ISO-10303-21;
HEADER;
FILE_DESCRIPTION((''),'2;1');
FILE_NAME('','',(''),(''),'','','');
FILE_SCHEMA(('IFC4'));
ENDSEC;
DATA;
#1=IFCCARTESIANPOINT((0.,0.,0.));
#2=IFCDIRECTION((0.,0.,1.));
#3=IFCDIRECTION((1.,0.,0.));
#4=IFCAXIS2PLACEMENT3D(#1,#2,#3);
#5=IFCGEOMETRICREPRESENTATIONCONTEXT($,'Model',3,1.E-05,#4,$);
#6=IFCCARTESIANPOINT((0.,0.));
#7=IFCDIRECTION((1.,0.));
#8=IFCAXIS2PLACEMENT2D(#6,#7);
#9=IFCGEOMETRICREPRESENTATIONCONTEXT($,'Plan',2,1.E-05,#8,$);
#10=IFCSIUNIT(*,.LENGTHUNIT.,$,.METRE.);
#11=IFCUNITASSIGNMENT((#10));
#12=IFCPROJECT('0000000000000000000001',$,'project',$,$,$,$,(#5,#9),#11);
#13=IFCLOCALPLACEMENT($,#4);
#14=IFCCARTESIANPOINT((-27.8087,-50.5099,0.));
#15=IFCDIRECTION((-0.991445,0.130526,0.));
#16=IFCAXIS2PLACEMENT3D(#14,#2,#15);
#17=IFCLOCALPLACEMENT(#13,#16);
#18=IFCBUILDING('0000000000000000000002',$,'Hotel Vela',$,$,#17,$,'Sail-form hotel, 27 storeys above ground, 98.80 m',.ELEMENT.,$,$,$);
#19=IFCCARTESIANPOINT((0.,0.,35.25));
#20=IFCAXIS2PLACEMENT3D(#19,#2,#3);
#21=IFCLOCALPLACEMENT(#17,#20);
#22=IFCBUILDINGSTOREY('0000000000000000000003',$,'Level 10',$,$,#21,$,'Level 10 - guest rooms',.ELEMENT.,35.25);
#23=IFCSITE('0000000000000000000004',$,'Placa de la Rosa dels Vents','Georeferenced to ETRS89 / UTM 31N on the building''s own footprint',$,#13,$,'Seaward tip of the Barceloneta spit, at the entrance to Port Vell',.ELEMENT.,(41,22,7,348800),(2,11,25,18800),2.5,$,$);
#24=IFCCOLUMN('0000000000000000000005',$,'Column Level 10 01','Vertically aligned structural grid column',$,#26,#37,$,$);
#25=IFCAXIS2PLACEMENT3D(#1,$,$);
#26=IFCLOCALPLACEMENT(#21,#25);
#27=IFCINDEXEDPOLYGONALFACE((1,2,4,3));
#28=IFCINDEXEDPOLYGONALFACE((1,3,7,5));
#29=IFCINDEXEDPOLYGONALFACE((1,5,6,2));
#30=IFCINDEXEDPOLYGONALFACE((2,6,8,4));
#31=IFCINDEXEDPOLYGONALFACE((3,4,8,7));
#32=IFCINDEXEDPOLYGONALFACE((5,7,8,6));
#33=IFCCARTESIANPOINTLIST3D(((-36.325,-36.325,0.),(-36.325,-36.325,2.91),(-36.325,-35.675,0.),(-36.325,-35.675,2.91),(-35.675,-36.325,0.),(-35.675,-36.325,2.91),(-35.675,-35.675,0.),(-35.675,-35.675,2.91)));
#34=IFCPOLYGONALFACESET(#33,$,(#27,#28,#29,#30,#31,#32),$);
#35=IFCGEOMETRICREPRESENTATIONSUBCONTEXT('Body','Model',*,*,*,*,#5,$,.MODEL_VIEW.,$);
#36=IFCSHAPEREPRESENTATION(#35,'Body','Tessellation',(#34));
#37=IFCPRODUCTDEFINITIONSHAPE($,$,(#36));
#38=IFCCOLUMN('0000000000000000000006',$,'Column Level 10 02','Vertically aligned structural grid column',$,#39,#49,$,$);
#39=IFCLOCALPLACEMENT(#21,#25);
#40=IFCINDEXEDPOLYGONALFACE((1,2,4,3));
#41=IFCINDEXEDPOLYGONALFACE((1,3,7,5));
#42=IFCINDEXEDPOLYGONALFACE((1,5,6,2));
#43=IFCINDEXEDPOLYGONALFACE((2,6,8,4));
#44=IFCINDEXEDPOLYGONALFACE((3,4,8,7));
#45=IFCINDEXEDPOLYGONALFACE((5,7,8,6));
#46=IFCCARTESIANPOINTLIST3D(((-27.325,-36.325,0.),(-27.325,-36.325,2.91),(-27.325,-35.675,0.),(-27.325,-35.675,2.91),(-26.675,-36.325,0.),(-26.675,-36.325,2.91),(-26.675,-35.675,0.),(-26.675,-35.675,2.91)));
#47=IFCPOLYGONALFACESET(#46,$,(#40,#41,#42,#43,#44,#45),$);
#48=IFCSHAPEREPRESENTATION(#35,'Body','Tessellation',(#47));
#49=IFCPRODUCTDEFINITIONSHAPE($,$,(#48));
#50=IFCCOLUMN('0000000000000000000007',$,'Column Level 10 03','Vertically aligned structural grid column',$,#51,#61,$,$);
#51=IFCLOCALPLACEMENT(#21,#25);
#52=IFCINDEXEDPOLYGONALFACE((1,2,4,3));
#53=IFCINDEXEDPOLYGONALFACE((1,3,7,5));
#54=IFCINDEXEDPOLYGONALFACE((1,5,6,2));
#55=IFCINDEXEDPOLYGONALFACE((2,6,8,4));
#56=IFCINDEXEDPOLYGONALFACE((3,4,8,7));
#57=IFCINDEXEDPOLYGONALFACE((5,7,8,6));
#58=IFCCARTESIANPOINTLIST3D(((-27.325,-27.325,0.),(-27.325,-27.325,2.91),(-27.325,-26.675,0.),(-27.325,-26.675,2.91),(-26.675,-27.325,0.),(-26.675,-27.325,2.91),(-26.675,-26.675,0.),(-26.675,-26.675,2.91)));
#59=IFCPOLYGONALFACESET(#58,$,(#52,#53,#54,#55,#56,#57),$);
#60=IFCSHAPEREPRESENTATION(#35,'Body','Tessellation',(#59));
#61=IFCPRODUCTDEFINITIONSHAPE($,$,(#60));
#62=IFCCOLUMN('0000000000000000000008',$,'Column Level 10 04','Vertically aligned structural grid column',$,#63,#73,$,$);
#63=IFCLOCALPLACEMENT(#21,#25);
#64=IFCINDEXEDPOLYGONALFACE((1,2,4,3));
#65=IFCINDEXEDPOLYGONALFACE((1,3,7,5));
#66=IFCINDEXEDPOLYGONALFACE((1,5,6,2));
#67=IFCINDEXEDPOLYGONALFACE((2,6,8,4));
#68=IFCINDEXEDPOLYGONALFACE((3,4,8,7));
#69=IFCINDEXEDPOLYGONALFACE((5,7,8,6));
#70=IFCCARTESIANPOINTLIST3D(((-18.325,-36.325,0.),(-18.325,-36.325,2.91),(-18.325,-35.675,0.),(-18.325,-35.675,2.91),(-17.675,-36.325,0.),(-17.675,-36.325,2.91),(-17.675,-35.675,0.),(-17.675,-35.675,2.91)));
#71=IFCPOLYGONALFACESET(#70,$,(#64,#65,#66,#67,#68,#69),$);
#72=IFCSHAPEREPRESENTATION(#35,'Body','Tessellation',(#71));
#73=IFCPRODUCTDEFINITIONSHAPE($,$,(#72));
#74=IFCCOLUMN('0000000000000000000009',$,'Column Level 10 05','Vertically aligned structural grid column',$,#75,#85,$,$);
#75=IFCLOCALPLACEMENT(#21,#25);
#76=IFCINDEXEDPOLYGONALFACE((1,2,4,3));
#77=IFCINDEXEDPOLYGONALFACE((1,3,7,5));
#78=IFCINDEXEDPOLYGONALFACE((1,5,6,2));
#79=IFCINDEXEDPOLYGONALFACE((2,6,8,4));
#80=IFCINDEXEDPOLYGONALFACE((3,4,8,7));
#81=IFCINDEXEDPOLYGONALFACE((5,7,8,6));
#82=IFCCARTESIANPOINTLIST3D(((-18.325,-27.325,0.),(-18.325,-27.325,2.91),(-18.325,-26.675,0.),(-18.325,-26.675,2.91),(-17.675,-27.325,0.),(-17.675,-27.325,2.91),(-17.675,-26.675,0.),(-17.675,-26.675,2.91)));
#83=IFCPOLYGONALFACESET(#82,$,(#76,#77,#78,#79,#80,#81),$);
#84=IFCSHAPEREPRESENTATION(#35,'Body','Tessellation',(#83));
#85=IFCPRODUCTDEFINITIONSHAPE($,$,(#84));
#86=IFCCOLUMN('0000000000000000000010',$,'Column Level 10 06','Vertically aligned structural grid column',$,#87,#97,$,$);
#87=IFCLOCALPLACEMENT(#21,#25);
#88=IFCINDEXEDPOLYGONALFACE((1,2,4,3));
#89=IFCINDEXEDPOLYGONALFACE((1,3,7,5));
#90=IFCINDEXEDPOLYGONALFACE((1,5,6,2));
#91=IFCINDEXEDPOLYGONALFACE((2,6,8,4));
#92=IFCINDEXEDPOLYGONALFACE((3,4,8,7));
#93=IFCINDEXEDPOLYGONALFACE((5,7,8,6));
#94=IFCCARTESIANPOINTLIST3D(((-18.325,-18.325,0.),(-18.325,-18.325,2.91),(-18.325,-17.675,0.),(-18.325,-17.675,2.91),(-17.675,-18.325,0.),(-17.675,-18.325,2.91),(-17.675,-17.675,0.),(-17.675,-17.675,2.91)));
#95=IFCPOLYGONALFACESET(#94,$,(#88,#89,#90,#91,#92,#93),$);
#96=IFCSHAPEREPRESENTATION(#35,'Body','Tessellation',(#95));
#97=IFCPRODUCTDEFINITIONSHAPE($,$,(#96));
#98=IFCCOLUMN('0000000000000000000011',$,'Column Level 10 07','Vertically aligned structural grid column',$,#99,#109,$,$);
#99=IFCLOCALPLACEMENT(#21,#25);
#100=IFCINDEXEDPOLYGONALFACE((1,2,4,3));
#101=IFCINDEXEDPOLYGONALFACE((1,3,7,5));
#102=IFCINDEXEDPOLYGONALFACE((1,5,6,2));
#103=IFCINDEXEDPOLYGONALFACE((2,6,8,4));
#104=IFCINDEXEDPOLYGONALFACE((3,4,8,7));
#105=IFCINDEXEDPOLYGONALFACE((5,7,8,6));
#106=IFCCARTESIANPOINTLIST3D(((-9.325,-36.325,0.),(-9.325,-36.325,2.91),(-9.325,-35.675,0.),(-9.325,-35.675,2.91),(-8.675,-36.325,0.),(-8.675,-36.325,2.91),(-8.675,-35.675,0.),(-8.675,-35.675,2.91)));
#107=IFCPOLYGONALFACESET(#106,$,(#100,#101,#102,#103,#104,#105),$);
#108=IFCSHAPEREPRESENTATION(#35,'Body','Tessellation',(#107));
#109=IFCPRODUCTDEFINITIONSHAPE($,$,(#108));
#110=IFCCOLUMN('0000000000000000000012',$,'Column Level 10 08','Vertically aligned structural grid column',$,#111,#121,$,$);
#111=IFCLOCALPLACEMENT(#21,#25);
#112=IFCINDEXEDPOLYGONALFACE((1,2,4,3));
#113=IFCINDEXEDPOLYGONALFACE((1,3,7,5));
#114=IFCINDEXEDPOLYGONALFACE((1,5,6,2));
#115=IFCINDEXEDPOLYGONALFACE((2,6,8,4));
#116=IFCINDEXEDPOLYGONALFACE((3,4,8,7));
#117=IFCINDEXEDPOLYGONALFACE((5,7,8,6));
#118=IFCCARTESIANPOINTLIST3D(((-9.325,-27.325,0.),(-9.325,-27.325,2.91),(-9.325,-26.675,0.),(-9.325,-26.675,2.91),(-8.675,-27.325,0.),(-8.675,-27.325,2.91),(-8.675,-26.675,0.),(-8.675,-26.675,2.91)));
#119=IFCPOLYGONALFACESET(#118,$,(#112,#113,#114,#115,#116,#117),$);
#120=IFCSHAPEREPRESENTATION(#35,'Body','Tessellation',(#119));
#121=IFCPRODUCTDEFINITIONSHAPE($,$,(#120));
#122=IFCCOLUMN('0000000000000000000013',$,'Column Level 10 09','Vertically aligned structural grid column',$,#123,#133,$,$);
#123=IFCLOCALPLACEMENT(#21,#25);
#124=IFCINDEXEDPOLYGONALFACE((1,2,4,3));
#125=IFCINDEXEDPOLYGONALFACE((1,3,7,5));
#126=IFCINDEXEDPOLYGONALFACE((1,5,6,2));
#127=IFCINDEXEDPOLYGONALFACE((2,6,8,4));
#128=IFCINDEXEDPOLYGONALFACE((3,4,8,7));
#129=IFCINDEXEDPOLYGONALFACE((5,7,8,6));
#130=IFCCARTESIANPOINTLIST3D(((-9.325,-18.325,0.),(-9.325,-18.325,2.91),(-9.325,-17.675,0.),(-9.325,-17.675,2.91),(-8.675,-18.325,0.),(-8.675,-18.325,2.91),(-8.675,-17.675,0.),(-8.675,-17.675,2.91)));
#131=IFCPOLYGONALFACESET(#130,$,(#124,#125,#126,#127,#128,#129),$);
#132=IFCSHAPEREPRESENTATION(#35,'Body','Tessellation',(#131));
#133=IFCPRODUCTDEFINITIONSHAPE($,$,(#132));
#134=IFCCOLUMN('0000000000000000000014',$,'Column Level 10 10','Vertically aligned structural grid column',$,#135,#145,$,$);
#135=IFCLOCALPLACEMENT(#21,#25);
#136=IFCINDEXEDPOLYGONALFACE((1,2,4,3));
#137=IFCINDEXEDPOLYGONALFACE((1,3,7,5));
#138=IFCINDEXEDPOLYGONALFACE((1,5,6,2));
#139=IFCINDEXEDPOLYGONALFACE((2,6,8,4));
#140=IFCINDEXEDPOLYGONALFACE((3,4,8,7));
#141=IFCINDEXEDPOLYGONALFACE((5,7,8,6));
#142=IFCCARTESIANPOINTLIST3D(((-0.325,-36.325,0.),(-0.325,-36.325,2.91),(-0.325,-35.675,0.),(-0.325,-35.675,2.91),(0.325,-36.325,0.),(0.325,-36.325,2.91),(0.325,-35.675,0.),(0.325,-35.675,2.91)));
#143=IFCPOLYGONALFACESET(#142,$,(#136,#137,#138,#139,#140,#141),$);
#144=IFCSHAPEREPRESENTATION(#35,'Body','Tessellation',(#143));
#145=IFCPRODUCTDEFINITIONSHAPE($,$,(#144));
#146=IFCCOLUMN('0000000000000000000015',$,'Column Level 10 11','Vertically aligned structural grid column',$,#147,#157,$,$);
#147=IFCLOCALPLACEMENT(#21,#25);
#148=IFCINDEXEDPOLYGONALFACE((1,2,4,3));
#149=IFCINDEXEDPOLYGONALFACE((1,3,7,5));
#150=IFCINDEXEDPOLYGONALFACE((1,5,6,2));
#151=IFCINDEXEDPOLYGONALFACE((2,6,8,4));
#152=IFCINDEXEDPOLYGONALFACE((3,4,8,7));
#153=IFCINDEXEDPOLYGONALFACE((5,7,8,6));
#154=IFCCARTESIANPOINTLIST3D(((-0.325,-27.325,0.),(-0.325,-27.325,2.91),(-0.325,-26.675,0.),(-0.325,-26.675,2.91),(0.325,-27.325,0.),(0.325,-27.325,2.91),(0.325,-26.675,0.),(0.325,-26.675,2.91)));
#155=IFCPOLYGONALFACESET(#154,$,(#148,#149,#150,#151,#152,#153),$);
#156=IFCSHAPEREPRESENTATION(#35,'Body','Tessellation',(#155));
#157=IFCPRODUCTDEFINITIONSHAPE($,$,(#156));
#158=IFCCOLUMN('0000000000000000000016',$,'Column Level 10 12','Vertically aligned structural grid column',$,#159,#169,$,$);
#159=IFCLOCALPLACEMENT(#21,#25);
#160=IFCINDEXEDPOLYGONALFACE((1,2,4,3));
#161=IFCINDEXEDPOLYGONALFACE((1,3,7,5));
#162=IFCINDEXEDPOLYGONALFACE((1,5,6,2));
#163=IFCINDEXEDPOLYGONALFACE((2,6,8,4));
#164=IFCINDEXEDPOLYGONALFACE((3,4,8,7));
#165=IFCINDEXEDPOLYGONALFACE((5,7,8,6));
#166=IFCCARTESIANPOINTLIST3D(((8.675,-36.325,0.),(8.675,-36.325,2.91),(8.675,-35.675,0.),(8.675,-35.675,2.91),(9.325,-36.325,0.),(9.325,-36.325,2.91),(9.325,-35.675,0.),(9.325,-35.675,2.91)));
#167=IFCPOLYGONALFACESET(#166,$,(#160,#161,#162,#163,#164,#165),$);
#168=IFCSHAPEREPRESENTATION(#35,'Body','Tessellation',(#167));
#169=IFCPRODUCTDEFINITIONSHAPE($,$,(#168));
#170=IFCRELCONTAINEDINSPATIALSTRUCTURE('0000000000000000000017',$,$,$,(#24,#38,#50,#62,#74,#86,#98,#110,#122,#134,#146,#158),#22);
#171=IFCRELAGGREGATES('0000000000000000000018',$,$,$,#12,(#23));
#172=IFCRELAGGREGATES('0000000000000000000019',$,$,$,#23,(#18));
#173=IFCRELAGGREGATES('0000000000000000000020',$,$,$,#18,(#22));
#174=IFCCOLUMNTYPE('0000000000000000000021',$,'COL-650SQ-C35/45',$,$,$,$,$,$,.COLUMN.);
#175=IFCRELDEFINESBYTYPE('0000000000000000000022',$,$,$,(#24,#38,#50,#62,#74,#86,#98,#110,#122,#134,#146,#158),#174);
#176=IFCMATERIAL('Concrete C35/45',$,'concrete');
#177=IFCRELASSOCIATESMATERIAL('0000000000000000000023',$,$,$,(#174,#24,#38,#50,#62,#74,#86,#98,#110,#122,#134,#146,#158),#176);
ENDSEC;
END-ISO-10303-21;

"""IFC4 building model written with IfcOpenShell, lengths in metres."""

from ifc_helpers import new_model, si_unit, frame, origin_with_axes, origin_2d_with_axis, place, context, subcontext, project, spatial, line, indexed_curve, rectangle, outline, extrude, material, material_profile, profile_set, profile_usage, type_object, element, save


model = new_model("IFC4")

# Units and contexts
model_context = context("Model", 3, precision=1e-05, world=origin_with_axes())
plan_context = context("Plan", 2, precision=1e-05, world=origin_2d_with_axis())
body_context = subcontext(model_context, "Body", "Model", "MODEL_VIEW")
ifc_project = project(units=[si_unit("LENGTHUNIT", "METRE")], contexts=[model_context, plan_context])

# Site, building, storey
site_placement = place(None, origin_with_axes())
site = spatial("IfcSite", under=ifc_project, at=site_placement, Name="Placa de la Rosa dels Vents", Description="Georeferenced to ETRS89 / UTM 31N on the building's own footprint", LongName="Seaward tip of the Barceloneta spit, at the entrance to Port Vell", CompositionType="ELEMENT", RefLatitude=(41, 22, 7, 348800), RefLongitude=(2, 11, 25, 18800), RefElevation=2.5)
building_placement = place(site_placement, frame((-27.8087, -50.5099, 0.0), z_axis=(0.0, 0.0, 1.0), x_axis=(-0.991445, 0.130526, 0.0)))
building = spatial("IfcBuilding", under=site, at=building_placement, Name="Hotel Vela", LongName="Sail-form hotel, 27 storeys above ground, 98.80 m", CompositionType="ELEMENT")
storey_placement = place(building_placement, frame((0.0, 0.0, 35.25), z_axis=(0.0, 0.0, 1.0), x_axis=(1.0, 0.0, 0.0)))
storey = spatial("IfcBuildingStorey", under=building, at=storey_placement, Name="Level 10", LongName="Level 10 - guest rooms", CompositionType="ELEMENT", Elevation=35.25)

# Columns
ifc_material = material(Name="Concrete C35/45", Category="concrete")
ifc_material_profile = material_profile(ifc_material, rectangle(XDim=0.65, YDim=0.65))
ifc_profile_set = profile_set([ifc_material_profile], Name="COL-650SQ-C35/45")
ifc_profile_usage_1 = profile_usage(ifc_profile_set)
column_type = type_object("IfcColumnType", Name="COL-650SQ-C35/45", PredefinedType="COLUMN", material=ifc_profile_set)
column_1_placement = place(storey_placement, frame((-36.325, -36.325, 0.0), z_axis=(0.0, 0.0, 1.0), x_axis=(1.0, 0.0, 0.0)))
element("IfcColumn", 1, at=column_1_placement, inside=storey, type_object=column_type, material=ifc_profile_usage_1, Name="Column Level 10 01", Description="Vertically aligned structural grid column", context=body_context, shape_type="SweptSolid", body=[
    extrude(outline(indexed_curve([(0.0, 0.0), (0.65, 0.0), (0.65, 0.65), (0.0, 0.65)], segments=[line(1, 2, 3, 4, 1)])), origin_with_axes(), (0.0, 0.0, 1.0), 2.91),
])
ifc_profile_usage_2 = profile_usage(ifc_profile_set)
column_2_placement = place(storey_placement, frame((-27.325, -36.325, 0.0), z_axis=(0.0, 0.0, 1.0), x_axis=(1.0, 0.0, 0.0)))
element("IfcColumn", 2, at=column_2_placement, inside=storey, type_object=column_type, material=ifc_profile_usage_2, Name="Column Level 10 02", Description="Vertically aligned structural grid column", context=body_context, shape_type="SweptSolid", body=[
    extrude(outline(indexed_curve([(0.0, 0.0), (0.65, 0.0), (0.65, 0.65), (0.0, 0.65)], segments=[line(1, 2, 3, 4, 1)])), origin_with_axes(), (0.0, 0.0, 1.0), 2.91),
])
ifc_profile_usage_3 = profile_usage(ifc_profile_set)
column_3_placement = place(storey_placement, frame((-27.325, -27.325, 0.0), z_axis=(0.0, 0.0, 1.0), x_axis=(1.0, 0.0, 0.0)))
element("IfcColumn", 3, at=column_3_placement, inside=storey, type_object=column_type, material=ifc_profile_usage_3, Name="Column Level 10 03", Description="Vertically aligned structural grid column", context=body_context, shape_type="SweptSolid", body=[
    extrude(outline(indexed_curve([(0.0, 0.0), (0.65, 0.0), (0.65, 0.65), (0.0, 0.65)], segments=[line(1, 2, 3, 4, 1)])), origin_with_axes(), (0.0, 0.0, 1.0), 2.91),
])
ifc_profile_usage_4 = profile_usage(ifc_profile_set)
column_4_placement = place(storey_placement, frame((-18.325, -36.325, 0.0), z_axis=(0.0, 0.0, 1.0), x_axis=(1.0, 0.0, 0.0)))
element("IfcColumn", 4, at=column_4_placement, inside=storey, type_object=column_type, material=ifc_profile_usage_4, Name="Column Level 10 04", Description="Vertically aligned structural grid column", context=body_context, shape_type="SweptSolid", body=[
    extrude(outline(indexed_curve([(0.0, 0.0), (0.65, 0.0), (0.65, 0.65), (0.0, 0.65)], segments=[line(1, 2, 3, 4, 1)])), origin_with_axes(), (0.0, 0.0, 1.0), 2.91),
])
ifc_profile_usage_5 = profile_usage(ifc_profile_set)
column_5_placement = place(storey_placement, frame((-18.325, -27.325, 0.0), z_axis=(0.0, 0.0, 1.0), x_axis=(1.0, 0.0, 0.0)))
element("IfcColumn", 5, at=column_5_placement, inside=storey, type_object=column_type, material=ifc_profile_usage_5, Name="Column Level 10 05", Description="Vertically aligned structural grid column", context=body_context, shape_type="SweptSolid", body=[
    extrude(outline(indexed_curve([(0.0, 0.0), (0.65, 0.0), (0.65, 0.65), (0.0, 0.65)], segments=[line(1, 2, 3, 4, 1)])), origin_with_axes(), (0.0, 0.0, 1.0), 2.91),
])
ifc_profile_usage_6 = profile_usage(ifc_profile_set)
column_6_placement = place(storey_placement, frame((-18.325, -18.325, 0.0), z_axis=(0.0, 0.0, 1.0), x_axis=(1.0, 0.0, 0.0)))
element("IfcColumn", 6, at=column_6_placement, inside=storey, type_object=column_type, material=ifc_profile_usage_6, Name="Column Level 10 06", Description="Vertically aligned structural grid column", context=body_context, shape_type="SweptSolid", body=[
    extrude(outline(indexed_curve([(0.0, 0.0), (0.65, 0.0), (0.65, 0.65), (0.0, 0.65)], segments=[line(1, 2, 3, 4, 1)])), origin_with_axes(), (0.0, 0.0, 1.0), 2.91),
])
ifc_profile_usage_7 = profile_usage(ifc_profile_set)
column_7_placement = place(storey_placement, frame((-9.325, -36.325, 0.0), z_axis=(0.0, 0.0, 1.0), x_axis=(1.0, 0.0, 0.0)))
element("IfcColumn", 7, at=column_7_placement, inside=storey, type_object=column_type, material=ifc_profile_usage_7, Name="Column Level 10 07", Description="Vertically aligned structural grid column", context=body_context, shape_type="SweptSolid", body=[
    extrude(outline(indexed_curve([(0.0, 0.0), (0.65, 0.0), (0.65, 0.65), (0.0, 0.65)], segments=[line(1, 2, 3, 4, 1)])), origin_with_axes(), (0.0, 0.0, 1.0), 2.91),
])
ifc_profile_usage_8 = profile_usage(ifc_profile_set)
column_8_placement = place(storey_placement, frame((-9.325, -27.325, 0.0), z_axis=(0.0, 0.0, 1.0), x_axis=(1.0, 0.0, 0.0)))
element("IfcColumn", 8, at=column_8_placement, inside=storey, type_object=column_type, material=ifc_profile_usage_8, Name="Column Level 10 08", Description="Vertically aligned structural grid column", context=body_context, shape_type="SweptSolid", body=[
    extrude(outline(indexed_curve([(0.0, 0.0), (0.65, 0.0), (0.65, 0.65), (0.0, 0.65)], segments=[line(1, 2, 3, 4, 1)])), origin_with_axes(), (0.0, 0.0, 1.0), 2.91),
])
ifc_profile_usage_9 = profile_usage(ifc_profile_set)
column_9_placement = place(storey_placement, frame((-9.325, -18.325, 0.0), z_axis=(0.0, 0.0, 1.0), x_axis=(1.0, 0.0, 0.0)))
element("IfcColumn", 9, at=column_9_placement, inside=storey, type_object=column_type, material=ifc_profile_usage_9, Name="Column Level 10 09", Description="Vertically aligned structural grid column", context=body_context, shape_type="SweptSolid", body=[
    extrude(outline(indexed_curve([(0.0, 0.0), (0.65, 0.0), (0.65, 0.65), (0.0, 0.65)], segments=[line(1, 2, 3, 4, 1)])), origin_with_axes(), (0.0, 0.0, 1.0), 2.91),
])
ifc_profile_usage_10 = profile_usage(ifc_profile_set)
column_10_placement = place(storey_placement, frame((-0.325, -36.325, 0.0), z_axis=(0.0, 0.0, 1.0), x_axis=(1.0, 0.0, 0.0)))
element("IfcColumn", 10, at=column_10_placement, inside=storey, type_object=column_type, material=ifc_profile_usage_10, Name="Column Level 10 10", Description="Vertically aligned structural grid column", context=body_context, shape_type="SweptSolid", body=[
    extrude(outline(indexed_curve([(0.0, 0.0), (0.65, 0.0), (0.65, 0.65), (0.0, 0.65)], segments=[line(1, 2, 3, 4, 1)])), origin_with_axes(), (0.0, 0.0, 1.0), 2.91),
])
ifc_profile_usage_11 = profile_usage(ifc_profile_set)
column_11_placement = place(storey_placement, frame((-0.325, -27.325, 0.0), z_axis=(0.0, 0.0, 1.0), x_axis=(1.0, 0.0, 0.0)))
element("IfcColumn", 11, at=column_11_placement, inside=storey, type_object=column_type, material=ifc_profile_usage_11, Name="Column Level 10 11", Description="Vertically aligned structural grid column", context=body_context, shape_type="SweptSolid", body=[
    extrude(outline(indexed_curve([(0.0, 0.0), (0.65, 0.0), (0.65, 0.65), (0.0, 0.65)], segments=[line(1, 2, 3, 4, 1)])), origin_with_axes(), (0.0, 0.0, 1.0), 2.91),
])
ifc_profile_usage_12 = profile_usage(ifc_profile_set)
column_12_placement = place(storey_placement, frame((8.675, -36.325, 0.0), z_axis=(0.0, 0.0, 1.0), x_axis=(1.0, 0.0, 0.0)))
element("IfcColumn", 12, at=column_12_placement, inside=storey, type_object=column_type, material=ifc_profile_usage_12, Name="Column Level 10 12", Description="Vertically aligned structural grid column", context=body_context, shape_type="SweptSolid", body=[
    extrude(outline(indexed_curve([(0.0, 0.0), (0.65, 0.0), (0.65, 0.65), (0.0, 0.65)], segments=[line(1, 2, 3, 4, 1)])), origin_with_axes(), (0.0, 0.0, 1.0), 2.91),
])

save(model, "model.ifc")
